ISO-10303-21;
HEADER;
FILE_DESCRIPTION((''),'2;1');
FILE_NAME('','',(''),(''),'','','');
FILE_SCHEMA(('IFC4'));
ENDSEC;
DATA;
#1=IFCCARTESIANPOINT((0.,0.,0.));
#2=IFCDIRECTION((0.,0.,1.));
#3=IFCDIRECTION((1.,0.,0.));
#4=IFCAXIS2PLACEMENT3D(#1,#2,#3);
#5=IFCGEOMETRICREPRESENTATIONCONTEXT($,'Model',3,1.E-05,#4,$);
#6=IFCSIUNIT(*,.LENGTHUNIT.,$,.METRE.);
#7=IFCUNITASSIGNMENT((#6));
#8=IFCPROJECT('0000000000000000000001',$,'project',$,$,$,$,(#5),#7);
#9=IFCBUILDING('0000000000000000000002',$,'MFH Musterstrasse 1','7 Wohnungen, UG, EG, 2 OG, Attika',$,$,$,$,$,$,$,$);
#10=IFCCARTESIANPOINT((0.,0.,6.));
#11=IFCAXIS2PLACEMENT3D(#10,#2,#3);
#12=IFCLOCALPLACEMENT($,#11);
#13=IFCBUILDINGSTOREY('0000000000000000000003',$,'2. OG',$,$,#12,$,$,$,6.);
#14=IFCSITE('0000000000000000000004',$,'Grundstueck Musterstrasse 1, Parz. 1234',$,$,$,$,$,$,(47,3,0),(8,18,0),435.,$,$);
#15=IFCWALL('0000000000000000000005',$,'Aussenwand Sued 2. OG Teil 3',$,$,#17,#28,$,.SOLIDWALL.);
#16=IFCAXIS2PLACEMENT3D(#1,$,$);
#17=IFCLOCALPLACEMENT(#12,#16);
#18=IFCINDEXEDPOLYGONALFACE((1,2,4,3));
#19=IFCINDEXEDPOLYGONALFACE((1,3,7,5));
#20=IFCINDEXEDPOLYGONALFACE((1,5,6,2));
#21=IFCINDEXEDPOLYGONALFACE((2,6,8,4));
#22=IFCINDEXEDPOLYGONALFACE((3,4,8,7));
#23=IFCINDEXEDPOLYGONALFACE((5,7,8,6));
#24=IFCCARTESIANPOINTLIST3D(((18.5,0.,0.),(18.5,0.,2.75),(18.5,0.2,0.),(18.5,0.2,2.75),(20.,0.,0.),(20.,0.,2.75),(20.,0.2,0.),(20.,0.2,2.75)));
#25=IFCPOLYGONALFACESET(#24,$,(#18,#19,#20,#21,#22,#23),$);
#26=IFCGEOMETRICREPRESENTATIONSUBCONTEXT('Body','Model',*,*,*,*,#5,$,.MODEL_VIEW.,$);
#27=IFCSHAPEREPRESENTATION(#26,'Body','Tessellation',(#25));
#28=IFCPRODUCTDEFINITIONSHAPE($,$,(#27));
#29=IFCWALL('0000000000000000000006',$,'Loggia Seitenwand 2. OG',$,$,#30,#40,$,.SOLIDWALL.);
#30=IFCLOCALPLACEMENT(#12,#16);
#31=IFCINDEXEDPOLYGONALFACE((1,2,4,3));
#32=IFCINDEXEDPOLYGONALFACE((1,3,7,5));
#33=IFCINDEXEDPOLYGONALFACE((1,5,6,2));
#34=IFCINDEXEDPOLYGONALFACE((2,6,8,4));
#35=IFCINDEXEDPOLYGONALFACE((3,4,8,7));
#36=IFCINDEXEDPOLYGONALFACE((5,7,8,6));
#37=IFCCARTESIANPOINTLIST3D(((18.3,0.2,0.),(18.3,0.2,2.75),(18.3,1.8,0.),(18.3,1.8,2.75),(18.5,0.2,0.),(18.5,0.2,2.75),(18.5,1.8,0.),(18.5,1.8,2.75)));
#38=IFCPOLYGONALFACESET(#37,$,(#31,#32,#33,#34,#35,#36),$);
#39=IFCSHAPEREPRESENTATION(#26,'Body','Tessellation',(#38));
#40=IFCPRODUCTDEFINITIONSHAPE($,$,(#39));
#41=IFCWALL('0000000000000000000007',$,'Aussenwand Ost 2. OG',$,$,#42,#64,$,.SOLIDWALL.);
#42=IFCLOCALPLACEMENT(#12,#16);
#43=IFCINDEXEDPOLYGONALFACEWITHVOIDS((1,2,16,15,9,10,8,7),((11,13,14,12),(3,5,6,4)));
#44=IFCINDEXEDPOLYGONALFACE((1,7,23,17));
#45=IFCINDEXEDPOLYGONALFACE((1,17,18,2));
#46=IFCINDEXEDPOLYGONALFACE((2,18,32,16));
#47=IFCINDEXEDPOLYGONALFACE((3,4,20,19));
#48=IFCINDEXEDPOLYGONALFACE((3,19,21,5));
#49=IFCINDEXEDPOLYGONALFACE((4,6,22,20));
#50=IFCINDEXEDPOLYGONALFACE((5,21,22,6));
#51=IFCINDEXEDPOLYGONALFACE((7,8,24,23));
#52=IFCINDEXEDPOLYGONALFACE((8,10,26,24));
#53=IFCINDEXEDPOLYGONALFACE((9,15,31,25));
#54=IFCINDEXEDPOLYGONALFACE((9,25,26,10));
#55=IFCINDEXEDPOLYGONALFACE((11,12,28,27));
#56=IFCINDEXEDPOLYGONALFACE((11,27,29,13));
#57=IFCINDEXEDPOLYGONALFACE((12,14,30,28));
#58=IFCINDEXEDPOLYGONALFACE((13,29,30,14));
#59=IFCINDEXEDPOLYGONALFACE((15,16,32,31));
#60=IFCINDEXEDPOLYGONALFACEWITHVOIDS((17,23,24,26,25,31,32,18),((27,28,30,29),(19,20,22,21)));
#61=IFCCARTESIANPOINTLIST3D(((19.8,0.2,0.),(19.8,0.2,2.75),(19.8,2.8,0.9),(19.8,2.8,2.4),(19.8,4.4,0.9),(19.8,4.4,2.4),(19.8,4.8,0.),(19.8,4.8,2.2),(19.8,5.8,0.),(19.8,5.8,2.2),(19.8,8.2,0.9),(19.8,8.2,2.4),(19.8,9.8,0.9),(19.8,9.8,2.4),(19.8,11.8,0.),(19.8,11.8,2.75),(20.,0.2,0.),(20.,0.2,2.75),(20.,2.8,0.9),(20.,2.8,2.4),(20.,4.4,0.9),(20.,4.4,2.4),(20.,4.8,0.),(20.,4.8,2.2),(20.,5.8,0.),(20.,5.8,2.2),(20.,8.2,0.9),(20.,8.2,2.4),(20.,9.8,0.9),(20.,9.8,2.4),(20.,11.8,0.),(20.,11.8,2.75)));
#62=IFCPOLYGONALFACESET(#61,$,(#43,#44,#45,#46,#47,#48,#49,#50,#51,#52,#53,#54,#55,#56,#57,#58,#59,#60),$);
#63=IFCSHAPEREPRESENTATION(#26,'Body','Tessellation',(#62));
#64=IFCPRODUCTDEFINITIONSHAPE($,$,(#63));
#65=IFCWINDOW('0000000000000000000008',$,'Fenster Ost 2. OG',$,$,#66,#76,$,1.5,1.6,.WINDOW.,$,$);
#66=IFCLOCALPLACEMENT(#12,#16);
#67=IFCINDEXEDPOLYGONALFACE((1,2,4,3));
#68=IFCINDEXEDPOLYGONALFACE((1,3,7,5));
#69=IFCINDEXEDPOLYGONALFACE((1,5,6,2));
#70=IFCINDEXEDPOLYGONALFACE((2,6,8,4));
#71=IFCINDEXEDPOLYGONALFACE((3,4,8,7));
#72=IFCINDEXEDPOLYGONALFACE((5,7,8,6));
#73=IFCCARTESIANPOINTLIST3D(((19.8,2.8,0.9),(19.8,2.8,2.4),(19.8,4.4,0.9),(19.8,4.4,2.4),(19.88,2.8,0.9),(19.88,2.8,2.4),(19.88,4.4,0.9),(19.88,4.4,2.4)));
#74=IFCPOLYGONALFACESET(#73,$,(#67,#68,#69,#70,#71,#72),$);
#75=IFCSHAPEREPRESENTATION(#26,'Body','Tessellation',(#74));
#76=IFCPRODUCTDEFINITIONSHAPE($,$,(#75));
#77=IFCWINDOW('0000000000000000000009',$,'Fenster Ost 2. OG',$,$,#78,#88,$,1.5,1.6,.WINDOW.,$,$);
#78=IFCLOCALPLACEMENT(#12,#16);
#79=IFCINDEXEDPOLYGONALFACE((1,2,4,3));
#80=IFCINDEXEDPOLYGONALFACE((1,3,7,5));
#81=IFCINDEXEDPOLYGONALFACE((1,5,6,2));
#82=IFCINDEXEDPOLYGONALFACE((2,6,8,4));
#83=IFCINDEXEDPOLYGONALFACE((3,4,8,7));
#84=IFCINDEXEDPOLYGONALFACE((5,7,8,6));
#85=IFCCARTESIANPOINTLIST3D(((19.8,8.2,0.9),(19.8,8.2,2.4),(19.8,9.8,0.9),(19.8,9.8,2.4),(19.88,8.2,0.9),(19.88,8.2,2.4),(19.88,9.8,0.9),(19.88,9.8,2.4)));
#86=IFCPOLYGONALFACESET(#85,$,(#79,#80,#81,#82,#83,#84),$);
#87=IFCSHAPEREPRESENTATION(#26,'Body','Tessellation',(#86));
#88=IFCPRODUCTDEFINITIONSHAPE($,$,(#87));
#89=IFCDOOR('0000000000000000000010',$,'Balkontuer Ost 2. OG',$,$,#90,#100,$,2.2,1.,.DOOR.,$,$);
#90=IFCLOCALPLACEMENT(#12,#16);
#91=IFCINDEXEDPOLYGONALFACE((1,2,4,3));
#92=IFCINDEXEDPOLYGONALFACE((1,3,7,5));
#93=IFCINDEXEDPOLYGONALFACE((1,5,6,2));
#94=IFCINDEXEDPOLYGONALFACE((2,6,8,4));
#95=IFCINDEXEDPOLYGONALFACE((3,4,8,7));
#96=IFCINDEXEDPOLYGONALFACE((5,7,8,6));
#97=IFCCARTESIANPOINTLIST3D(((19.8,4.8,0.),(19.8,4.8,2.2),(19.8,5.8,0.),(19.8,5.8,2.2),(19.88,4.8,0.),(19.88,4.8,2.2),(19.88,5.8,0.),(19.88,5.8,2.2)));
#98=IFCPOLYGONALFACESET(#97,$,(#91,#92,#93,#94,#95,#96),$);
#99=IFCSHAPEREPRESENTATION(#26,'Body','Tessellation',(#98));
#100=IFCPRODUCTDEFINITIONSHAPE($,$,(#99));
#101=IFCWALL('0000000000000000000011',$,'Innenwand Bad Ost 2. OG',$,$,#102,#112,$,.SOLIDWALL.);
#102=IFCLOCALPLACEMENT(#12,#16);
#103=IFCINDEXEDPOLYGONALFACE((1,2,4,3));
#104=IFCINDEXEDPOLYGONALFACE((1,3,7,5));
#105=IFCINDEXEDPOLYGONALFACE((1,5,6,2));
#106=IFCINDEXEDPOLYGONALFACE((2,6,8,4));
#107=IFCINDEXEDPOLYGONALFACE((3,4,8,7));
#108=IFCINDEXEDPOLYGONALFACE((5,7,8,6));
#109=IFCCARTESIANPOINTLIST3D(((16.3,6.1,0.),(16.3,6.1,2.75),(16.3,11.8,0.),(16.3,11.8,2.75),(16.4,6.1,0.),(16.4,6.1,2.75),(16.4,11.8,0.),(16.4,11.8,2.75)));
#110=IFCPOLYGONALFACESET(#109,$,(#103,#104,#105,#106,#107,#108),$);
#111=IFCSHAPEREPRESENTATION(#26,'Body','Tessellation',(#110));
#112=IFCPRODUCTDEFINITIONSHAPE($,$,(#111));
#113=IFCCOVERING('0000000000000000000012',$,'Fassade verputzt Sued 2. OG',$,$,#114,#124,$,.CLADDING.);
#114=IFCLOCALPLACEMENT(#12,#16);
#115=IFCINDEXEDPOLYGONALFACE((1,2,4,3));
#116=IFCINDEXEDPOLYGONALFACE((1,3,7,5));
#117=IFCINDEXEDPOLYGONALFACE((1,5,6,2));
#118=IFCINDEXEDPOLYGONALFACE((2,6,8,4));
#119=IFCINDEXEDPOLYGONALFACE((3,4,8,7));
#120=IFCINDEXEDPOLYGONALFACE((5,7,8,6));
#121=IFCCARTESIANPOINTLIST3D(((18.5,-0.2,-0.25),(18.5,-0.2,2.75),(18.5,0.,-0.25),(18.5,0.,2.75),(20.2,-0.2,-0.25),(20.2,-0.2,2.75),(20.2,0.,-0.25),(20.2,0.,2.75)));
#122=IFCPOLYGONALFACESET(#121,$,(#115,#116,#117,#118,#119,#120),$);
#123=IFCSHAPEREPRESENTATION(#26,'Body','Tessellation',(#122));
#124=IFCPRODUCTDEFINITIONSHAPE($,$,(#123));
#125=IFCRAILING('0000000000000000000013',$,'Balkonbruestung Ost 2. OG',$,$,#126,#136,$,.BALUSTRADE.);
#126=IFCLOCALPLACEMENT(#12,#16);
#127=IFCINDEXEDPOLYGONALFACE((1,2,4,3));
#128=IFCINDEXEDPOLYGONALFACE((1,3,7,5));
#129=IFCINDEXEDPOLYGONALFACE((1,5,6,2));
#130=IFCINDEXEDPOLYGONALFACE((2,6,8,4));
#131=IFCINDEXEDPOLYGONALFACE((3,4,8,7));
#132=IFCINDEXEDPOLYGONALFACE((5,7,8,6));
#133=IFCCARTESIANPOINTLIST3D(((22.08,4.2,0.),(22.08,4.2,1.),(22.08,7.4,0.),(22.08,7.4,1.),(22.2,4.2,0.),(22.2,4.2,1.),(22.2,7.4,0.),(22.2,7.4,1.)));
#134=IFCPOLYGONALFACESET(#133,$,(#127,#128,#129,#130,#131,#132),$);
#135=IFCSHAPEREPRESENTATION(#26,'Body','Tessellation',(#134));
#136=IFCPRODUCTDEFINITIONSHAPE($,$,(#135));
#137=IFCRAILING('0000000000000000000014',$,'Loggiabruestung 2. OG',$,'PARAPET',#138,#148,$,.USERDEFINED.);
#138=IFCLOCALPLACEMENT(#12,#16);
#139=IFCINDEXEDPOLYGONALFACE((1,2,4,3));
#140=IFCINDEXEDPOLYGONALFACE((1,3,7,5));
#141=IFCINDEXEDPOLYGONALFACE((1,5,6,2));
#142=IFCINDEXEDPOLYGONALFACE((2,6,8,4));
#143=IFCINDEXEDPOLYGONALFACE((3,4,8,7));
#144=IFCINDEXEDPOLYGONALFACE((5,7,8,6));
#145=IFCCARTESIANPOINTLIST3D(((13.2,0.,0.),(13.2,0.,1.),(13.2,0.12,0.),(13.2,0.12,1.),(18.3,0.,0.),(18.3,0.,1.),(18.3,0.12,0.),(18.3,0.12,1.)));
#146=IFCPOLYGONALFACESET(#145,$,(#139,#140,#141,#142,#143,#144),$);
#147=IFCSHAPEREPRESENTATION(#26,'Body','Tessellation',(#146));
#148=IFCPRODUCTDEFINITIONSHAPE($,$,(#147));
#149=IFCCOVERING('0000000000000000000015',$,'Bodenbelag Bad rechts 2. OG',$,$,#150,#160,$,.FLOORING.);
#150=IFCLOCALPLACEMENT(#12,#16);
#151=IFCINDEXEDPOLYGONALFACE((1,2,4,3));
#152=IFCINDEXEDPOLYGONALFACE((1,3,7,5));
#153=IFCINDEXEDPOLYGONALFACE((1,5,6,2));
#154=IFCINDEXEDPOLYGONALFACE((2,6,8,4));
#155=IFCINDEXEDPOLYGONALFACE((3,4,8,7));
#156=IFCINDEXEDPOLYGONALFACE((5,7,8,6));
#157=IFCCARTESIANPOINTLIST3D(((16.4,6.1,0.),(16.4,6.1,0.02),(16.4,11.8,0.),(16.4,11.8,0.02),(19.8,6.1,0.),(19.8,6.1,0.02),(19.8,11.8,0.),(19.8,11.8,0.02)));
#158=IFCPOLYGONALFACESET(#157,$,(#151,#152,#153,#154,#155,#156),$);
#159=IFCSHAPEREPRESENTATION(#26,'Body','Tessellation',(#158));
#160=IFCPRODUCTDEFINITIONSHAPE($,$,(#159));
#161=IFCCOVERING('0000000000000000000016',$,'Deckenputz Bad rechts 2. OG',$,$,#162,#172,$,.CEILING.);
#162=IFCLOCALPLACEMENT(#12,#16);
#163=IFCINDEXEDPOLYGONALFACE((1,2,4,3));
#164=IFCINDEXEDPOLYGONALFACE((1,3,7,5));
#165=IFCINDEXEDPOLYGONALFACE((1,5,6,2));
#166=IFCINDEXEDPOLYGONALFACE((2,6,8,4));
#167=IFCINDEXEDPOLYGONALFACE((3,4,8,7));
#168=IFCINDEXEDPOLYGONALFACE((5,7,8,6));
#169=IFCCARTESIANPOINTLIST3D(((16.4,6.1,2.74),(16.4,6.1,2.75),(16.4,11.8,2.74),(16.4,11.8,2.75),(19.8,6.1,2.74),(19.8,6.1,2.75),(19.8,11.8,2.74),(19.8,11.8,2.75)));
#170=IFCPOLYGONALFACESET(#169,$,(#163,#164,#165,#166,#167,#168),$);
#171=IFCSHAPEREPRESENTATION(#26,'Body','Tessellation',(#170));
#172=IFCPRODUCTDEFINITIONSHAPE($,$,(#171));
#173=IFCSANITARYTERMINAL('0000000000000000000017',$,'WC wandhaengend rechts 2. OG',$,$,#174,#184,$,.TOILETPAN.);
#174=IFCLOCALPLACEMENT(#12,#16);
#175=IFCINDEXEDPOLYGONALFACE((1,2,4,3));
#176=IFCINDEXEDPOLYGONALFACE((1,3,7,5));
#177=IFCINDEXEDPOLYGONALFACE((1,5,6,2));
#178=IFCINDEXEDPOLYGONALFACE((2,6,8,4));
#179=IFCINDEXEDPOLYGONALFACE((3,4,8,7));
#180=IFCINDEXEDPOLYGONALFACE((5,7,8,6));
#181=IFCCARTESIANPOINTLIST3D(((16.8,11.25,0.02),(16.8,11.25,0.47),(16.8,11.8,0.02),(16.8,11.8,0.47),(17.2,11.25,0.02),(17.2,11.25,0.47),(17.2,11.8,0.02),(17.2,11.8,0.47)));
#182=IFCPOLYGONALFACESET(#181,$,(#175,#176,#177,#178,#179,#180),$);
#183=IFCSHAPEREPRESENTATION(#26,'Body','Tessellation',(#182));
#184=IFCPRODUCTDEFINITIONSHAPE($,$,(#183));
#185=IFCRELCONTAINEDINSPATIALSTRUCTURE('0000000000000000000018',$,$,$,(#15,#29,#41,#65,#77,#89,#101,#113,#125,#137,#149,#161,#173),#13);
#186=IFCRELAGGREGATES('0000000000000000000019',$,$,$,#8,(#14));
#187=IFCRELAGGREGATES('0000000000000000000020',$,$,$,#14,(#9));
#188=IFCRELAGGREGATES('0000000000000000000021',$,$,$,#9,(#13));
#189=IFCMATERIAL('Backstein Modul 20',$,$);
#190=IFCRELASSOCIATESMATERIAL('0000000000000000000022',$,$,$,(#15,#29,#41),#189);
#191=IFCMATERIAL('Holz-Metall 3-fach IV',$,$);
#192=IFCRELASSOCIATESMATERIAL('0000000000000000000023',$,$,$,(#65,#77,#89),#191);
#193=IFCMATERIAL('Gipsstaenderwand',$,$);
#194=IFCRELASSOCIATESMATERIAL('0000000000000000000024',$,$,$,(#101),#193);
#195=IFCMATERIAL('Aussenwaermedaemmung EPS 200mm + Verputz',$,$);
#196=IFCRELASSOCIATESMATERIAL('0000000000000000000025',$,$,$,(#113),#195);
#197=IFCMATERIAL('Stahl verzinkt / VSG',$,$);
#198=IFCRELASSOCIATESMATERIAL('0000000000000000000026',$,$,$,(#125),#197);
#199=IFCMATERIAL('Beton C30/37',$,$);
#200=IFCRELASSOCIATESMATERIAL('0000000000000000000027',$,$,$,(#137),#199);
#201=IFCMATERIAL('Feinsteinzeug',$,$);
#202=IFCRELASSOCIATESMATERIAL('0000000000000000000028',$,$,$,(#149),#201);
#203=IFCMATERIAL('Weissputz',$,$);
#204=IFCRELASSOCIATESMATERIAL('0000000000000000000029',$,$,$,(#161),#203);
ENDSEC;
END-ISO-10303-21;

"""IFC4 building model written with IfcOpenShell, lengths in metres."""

from ifc_helpers import new_model, si_unit, frame, frame_2d, origin_with_axes, place, context, subcontext, project, spatial, rectangle, extrude, material, element, fill, save


model = new_model("IFC4")

# Units and contexts
model_context = context("Model", 3, precision=1e-05, world=origin_with_axes())
body_context = subcontext(model_context, "Body", "Model", "MODEL_VIEW")
ifc_project = project(units=[si_unit("LENGTHUNIT", "METRE")], contexts=[model_context])

# Site, building, storey
site = spatial("IfcSite", under=ifc_project, Name="Grundstueck Musterstrasse 1, Parz. 1234", RefLatitude=(47, 3, 0), RefLongitude=(8, 18, 0), RefElevation=435.0)
building = spatial("IfcBuilding", under=site, Name="MFH Musterstrasse 1", Description="7 Wohnungen, UG, EG, 2 OG, Attika")
storey_placement = place(None, frame((0.0, 0.0, 6.0), z_axis=(0.0, 0.0, 1.0), x_axis=(1.0, 0.0, 0.0)))
storey = spatial("IfcBuildingStorey", under=building, at=storey_placement, Name="2. OG", Elevation=6.0)

# Walls
ifc_material_1 = material(Name="Backstein Modul 20")
wall_1_placement = place(storey_placement, frame((18.5, 0.0, 0.0), z_axis=(0.0, 0.0, 1.0), x_axis=(1.0, 0.0, 0.0)))
element("IfcWall", 1, at=wall_1_placement, inside=storey, material=ifc_material_1, Name="Aussenwand Sued 2. OG Teil 3", PredefinedType="SOLIDWALL", context=body_context, shape_type="SweptSolid", body=[
    extrude(rectangle(XDim=1.5, YDim=0.2, at=frame_2d((0.75, 0.1))), origin_with_axes(), (0.0, 0.0, 1.0), 2.75),
])
wall_2_placement = place(storey_placement, frame((18.3, 0.2, 0.0), z_axis=(0.0, 0.0, 1.0), x_axis=(1.0, 0.0, 0.0)))
element("IfcWall", 2, at=wall_2_placement, inside=storey, material=ifc_material_1, Name="Loggia Seitenwand 2. OG", PredefinedType="SOLIDWALL", context=body_context, shape_type="SweptSolid", body=[
    extrude(rectangle(XDim=0.2, YDim=1.6, at=frame_2d((0.1, 0.8))), origin_with_axes(), (0.0, 0.0, 1.0), 2.75),
])

# Wall, openings, windows, door
wall_3_placement = place(storey_placement, frame((19.8, 0.2, 0.0), z_axis=(0.0, 0.0, 1.0), x_axis=(1.0, 0.0, 0.0)))
wall_3 = element("IfcWall", 3, at=wall_3_placement, inside=storey, material=ifc_material_1, Name="Aussenwand Ost 2. OG", PredefinedType="SOLIDWALL", context=body_context, shape_type="SweptSolid", body=[
    extrude(rectangle(XDim=0.2, YDim=11.6, at=frame_2d((0.1, 5.8))), origin_with_axes(), (0.0, 0.0, 1.0), 2.75),
])
opening_1_placement = place(wall_3_placement, frame((-0.01, 2.6, 0.9), z_axis=(0.0, 0.0, 1.0), x_axis=(1.0, 0.0, 0.0)))
opening_1 = element("IfcOpeningElement", 4, at=opening_1_placement, cuts=wall_3, context=body_context, shape_type="SweptSolid", body=[
    extrude(rectangle(XDim=0.42, YDim=1.6, at=frame_2d((0.21, 0.8))), origin_with_axes(), (0.0, 0.0, 1.0), 1.5),
])
opening_2_placement = place(wall_3_placement, frame((-0.01, 8.0, 0.9), z_axis=(0.0, 0.0, 1.0), x_axis=(1.0, 0.0, 0.0)))
opening_2 = element("IfcOpeningElement", 5, at=opening_2_placement, cuts=wall_3, context=body_context, shape_type="SweptSolid", body=[
    extrude(rectangle(XDim=0.42, YDim=1.6, at=frame_2d((0.21, 0.8))), origin_with_axes(), (0.0, 0.0, 1.0), 1.5),
])
opening_3_placement = place(wall_3_placement, frame((-0.01, 4.6, 0.0), z_axis=(0.0, 0.0, 1.0), x_axis=(1.0, 0.0, 0.0)))
opening_3 = element("IfcOpeningElement", 6, at=opening_3_placement, cuts=wall_3, context=body_context, shape_type="SweptSolid", body=[
    extrude(rectangle(XDim=0.42, YDim=1.0, at=frame_2d((0.21, 0.5))), origin_with_axes(), (0.0, 0.0, 1.0), 2.2),
])
ifc_material_2 = material(Name="Holz-Metall 3-fach IV")
window_1_placement = place(storey_placement, frame((19.8, 2.8, 0.9), z_axis=(0.0, 0.0, 1.0), x_axis=(1.0, 0.0, 0.0)))
window_1 = element("IfcWindow", 7, at=window_1_placement, inside=storey, material=ifc_material_2, Name="Fenster Ost 2. OG", OverallHeight=1.5, OverallWidth=1.6, PredefinedType="WINDOW", context=body_context, shape_type="SweptSolid", body=[
    extrude(rectangle(XDim=0.08, YDim=1.6, at=frame_2d((0.04, 0.8))), origin_with_axes(), (0.0, 0.0, 1.0), 1.5),
])
fill(opening_1, window_1)
window_2_placement = place(storey_placement, frame((19.8, 8.2, 0.9), z_axis=(0.0, 0.0, 1.0), x_axis=(1.0, 0.0, 0.0)))
window_2 = element("IfcWindow", 8, at=window_2_placement, inside=storey, material=ifc_material_2, Name="Fenster Ost 2. OG", OverallHeight=1.5, OverallWidth=1.6, PredefinedType="WINDOW", context=body_context, shape_type="SweptSolid", body=[
    extrude(rectangle(XDim=0.08, YDim=1.6, at=frame_2d((0.04, 0.8))), origin_with_axes(), (0.0, 0.0, 1.0), 1.5),
])
fill(opening_2, window_2)
door_placement = place(storey_placement, frame((19.8, 4.8, 0.0), z_axis=(0.0, 0.0, 1.0), x_axis=(1.0, 0.0, 0.0)))
door = element("IfcDoor", 9, at=door_placement, inside=storey, material=ifc_material_2, Name="Balkontuer Ost 2. OG", OverallHeight=2.2, OverallWidth=1.0, PredefinedType="DOOR", context=body_context, shape_type="SweptSolid", body=[
    extrude(rectangle(XDim=0.08, YDim=1.0, at=frame_2d((0.04, 0.5))), origin_with_axes(), (0.0, 0.0, 1.0), 2.2),
])
fill(opening_3, door)

# Wall
ifc_material_3 = material(Name="Gipsstaenderwand")
wall_4_placement = place(storey_placement, frame((16.3, 6.1, 0.0), z_axis=(0.0, 0.0, 1.0), x_axis=(1.0, 0.0, 0.0)))
element("IfcWall", 10, at=wall_4_placement, inside=storey, material=ifc_material_3, Name="Innenwand Bad Ost 2. OG", PredefinedType="SOLIDWALL", context=body_context, shape_type="SweptSolid", body=[
    extrude(rectangle(XDim=0.1, YDim=5.7, at=frame_2d((0.05, 2.85))), origin_with_axes(), (0.0, 0.0, 1.0), 2.75),
])

# Shared definitions
ifc_material_4 = material(Name="Aussenwaermedaemmung EPS 200mm + Verputz")

# Covering
covering_1_placement = place(storey_placement, frame((18.5, -0.2, -0.25), z_axis=(0.0, 0.0, 1.0), x_axis=(1.0, 0.0, 0.0)))
element("IfcCovering", 11, at=covering_1_placement, inside=storey, material=ifc_material_4, Name="Fassade verputzt Sued 2. OG", PredefinedType="CLADDING", context=body_context, shape_type="SweptSolid", body=[
    extrude(rectangle(XDim=1.7, YDim=0.2, at=frame_2d((0.85, 0.1))), origin_with_axes(), (0.0, 0.0, 1.0), 3.0),
])

# Railings
ifc_material_5 = material(Name="Stahl verzinkt / VSG")
railing_1_placement = place(storey_placement, frame((22.08, 4.2, 0.0), z_axis=(0.0, 0.0, 1.0), x_axis=(1.0, 0.0, 0.0)))
element("IfcRailing", 12, at=railing_1_placement, inside=storey, material=ifc_material_5, Name="Balkonbruestung Ost 2. OG", PredefinedType="BALUSTRADE", context=body_context, shape_type="SweptSolid", body=[
    extrude(rectangle(XDim=0.12, YDim=3.2, at=frame_2d((0.06, 1.6))), origin_with_axes(), (0.0, 0.0, 1.0), 1.0),
])
ifc_material_6 = material(Name="Beton C30/37")
railing_2_placement = place(storey_placement, frame((13.2, 0.0, 0.0), z_axis=(0.0, 0.0, 1.0), x_axis=(1.0, 0.0, 0.0)))
element("IfcRailing", 13, at=railing_2_placement, inside=storey, material=ifc_material_6, Name="Loggiabruestung 2. OG", ObjectType="PARAPET", PredefinedType="USERDEFINED", context=body_context, shape_type="SweptSolid", body=[
    extrude(rectangle(XDim=5.1, YDim=0.12, at=frame_2d((2.55, 0.06))), origin_with_axes(), (0.0, 0.0, 1.0), 1.0),
])

# Coverings
ifc_material_7 = material(Name="Feinsteinzeug")
covering_2_placement = place(storey_placement, frame((16.4, 6.1, 0.0), z_axis=(0.0, 0.0, 1.0), x_axis=(1.0, 0.0, 0.0)))
element("IfcCovering", 14, at=covering_2_placement, inside=storey, material=ifc_material_7, Name="Bodenbelag Bad rechts 2. OG", PredefinedType="FLOORING", context=body_context, shape_type="SweptSolid", body=[
    extrude(rectangle(XDim=3.4, YDim=5.7, at=frame_2d((1.7, 2.85))), origin_with_axes(), (0.0, 0.0, 1.0), 0.02),
])
ifc_material_8 = material(Name="Weissputz")
covering_3_placement = place(storey_placement, frame((16.4, 6.1, 2.74), z_axis=(0.0, 0.0, 1.0), x_axis=(1.0, 0.0, 0.0)))
element("IfcCovering", 15, at=covering_3_placement, inside=storey, material=ifc_material_8, Name="Deckenputz Bad rechts 2. OG", PredefinedType="CEILING", context=body_context, shape_type="SweptSolid", body=[
    extrude(rectangle(XDim=3.4, YDim=5.7, at=frame_2d((1.7, 2.85))), origin_with_axes(), (0.0, 0.0, 1.0), 0.01),
])

# Sanitary terminal
sanitary_terminal_1_placement = place(storey_placement, frame((16.8, 11.25, 0.02), z_axis=(0.0, 0.0, 1.0), x_axis=(1.0, 0.0, 0.0)))
element("IfcSanitaryTerminal", 16, at=sanitary_terminal_1_placement, inside=storey, Name="WC wandhaengend rechts 2. OG", PredefinedType="TOILETPAN", context=body_context, shape_type="SweptSolid", body=[
    extrude(rectangle(XDim=0.4, YDim=0.55, at=frame_2d((0.2, 0.275))), origin_with_axes(), (0.0, 0.0, 1.0), 0.45),
])

save(model, "model.ifc")
